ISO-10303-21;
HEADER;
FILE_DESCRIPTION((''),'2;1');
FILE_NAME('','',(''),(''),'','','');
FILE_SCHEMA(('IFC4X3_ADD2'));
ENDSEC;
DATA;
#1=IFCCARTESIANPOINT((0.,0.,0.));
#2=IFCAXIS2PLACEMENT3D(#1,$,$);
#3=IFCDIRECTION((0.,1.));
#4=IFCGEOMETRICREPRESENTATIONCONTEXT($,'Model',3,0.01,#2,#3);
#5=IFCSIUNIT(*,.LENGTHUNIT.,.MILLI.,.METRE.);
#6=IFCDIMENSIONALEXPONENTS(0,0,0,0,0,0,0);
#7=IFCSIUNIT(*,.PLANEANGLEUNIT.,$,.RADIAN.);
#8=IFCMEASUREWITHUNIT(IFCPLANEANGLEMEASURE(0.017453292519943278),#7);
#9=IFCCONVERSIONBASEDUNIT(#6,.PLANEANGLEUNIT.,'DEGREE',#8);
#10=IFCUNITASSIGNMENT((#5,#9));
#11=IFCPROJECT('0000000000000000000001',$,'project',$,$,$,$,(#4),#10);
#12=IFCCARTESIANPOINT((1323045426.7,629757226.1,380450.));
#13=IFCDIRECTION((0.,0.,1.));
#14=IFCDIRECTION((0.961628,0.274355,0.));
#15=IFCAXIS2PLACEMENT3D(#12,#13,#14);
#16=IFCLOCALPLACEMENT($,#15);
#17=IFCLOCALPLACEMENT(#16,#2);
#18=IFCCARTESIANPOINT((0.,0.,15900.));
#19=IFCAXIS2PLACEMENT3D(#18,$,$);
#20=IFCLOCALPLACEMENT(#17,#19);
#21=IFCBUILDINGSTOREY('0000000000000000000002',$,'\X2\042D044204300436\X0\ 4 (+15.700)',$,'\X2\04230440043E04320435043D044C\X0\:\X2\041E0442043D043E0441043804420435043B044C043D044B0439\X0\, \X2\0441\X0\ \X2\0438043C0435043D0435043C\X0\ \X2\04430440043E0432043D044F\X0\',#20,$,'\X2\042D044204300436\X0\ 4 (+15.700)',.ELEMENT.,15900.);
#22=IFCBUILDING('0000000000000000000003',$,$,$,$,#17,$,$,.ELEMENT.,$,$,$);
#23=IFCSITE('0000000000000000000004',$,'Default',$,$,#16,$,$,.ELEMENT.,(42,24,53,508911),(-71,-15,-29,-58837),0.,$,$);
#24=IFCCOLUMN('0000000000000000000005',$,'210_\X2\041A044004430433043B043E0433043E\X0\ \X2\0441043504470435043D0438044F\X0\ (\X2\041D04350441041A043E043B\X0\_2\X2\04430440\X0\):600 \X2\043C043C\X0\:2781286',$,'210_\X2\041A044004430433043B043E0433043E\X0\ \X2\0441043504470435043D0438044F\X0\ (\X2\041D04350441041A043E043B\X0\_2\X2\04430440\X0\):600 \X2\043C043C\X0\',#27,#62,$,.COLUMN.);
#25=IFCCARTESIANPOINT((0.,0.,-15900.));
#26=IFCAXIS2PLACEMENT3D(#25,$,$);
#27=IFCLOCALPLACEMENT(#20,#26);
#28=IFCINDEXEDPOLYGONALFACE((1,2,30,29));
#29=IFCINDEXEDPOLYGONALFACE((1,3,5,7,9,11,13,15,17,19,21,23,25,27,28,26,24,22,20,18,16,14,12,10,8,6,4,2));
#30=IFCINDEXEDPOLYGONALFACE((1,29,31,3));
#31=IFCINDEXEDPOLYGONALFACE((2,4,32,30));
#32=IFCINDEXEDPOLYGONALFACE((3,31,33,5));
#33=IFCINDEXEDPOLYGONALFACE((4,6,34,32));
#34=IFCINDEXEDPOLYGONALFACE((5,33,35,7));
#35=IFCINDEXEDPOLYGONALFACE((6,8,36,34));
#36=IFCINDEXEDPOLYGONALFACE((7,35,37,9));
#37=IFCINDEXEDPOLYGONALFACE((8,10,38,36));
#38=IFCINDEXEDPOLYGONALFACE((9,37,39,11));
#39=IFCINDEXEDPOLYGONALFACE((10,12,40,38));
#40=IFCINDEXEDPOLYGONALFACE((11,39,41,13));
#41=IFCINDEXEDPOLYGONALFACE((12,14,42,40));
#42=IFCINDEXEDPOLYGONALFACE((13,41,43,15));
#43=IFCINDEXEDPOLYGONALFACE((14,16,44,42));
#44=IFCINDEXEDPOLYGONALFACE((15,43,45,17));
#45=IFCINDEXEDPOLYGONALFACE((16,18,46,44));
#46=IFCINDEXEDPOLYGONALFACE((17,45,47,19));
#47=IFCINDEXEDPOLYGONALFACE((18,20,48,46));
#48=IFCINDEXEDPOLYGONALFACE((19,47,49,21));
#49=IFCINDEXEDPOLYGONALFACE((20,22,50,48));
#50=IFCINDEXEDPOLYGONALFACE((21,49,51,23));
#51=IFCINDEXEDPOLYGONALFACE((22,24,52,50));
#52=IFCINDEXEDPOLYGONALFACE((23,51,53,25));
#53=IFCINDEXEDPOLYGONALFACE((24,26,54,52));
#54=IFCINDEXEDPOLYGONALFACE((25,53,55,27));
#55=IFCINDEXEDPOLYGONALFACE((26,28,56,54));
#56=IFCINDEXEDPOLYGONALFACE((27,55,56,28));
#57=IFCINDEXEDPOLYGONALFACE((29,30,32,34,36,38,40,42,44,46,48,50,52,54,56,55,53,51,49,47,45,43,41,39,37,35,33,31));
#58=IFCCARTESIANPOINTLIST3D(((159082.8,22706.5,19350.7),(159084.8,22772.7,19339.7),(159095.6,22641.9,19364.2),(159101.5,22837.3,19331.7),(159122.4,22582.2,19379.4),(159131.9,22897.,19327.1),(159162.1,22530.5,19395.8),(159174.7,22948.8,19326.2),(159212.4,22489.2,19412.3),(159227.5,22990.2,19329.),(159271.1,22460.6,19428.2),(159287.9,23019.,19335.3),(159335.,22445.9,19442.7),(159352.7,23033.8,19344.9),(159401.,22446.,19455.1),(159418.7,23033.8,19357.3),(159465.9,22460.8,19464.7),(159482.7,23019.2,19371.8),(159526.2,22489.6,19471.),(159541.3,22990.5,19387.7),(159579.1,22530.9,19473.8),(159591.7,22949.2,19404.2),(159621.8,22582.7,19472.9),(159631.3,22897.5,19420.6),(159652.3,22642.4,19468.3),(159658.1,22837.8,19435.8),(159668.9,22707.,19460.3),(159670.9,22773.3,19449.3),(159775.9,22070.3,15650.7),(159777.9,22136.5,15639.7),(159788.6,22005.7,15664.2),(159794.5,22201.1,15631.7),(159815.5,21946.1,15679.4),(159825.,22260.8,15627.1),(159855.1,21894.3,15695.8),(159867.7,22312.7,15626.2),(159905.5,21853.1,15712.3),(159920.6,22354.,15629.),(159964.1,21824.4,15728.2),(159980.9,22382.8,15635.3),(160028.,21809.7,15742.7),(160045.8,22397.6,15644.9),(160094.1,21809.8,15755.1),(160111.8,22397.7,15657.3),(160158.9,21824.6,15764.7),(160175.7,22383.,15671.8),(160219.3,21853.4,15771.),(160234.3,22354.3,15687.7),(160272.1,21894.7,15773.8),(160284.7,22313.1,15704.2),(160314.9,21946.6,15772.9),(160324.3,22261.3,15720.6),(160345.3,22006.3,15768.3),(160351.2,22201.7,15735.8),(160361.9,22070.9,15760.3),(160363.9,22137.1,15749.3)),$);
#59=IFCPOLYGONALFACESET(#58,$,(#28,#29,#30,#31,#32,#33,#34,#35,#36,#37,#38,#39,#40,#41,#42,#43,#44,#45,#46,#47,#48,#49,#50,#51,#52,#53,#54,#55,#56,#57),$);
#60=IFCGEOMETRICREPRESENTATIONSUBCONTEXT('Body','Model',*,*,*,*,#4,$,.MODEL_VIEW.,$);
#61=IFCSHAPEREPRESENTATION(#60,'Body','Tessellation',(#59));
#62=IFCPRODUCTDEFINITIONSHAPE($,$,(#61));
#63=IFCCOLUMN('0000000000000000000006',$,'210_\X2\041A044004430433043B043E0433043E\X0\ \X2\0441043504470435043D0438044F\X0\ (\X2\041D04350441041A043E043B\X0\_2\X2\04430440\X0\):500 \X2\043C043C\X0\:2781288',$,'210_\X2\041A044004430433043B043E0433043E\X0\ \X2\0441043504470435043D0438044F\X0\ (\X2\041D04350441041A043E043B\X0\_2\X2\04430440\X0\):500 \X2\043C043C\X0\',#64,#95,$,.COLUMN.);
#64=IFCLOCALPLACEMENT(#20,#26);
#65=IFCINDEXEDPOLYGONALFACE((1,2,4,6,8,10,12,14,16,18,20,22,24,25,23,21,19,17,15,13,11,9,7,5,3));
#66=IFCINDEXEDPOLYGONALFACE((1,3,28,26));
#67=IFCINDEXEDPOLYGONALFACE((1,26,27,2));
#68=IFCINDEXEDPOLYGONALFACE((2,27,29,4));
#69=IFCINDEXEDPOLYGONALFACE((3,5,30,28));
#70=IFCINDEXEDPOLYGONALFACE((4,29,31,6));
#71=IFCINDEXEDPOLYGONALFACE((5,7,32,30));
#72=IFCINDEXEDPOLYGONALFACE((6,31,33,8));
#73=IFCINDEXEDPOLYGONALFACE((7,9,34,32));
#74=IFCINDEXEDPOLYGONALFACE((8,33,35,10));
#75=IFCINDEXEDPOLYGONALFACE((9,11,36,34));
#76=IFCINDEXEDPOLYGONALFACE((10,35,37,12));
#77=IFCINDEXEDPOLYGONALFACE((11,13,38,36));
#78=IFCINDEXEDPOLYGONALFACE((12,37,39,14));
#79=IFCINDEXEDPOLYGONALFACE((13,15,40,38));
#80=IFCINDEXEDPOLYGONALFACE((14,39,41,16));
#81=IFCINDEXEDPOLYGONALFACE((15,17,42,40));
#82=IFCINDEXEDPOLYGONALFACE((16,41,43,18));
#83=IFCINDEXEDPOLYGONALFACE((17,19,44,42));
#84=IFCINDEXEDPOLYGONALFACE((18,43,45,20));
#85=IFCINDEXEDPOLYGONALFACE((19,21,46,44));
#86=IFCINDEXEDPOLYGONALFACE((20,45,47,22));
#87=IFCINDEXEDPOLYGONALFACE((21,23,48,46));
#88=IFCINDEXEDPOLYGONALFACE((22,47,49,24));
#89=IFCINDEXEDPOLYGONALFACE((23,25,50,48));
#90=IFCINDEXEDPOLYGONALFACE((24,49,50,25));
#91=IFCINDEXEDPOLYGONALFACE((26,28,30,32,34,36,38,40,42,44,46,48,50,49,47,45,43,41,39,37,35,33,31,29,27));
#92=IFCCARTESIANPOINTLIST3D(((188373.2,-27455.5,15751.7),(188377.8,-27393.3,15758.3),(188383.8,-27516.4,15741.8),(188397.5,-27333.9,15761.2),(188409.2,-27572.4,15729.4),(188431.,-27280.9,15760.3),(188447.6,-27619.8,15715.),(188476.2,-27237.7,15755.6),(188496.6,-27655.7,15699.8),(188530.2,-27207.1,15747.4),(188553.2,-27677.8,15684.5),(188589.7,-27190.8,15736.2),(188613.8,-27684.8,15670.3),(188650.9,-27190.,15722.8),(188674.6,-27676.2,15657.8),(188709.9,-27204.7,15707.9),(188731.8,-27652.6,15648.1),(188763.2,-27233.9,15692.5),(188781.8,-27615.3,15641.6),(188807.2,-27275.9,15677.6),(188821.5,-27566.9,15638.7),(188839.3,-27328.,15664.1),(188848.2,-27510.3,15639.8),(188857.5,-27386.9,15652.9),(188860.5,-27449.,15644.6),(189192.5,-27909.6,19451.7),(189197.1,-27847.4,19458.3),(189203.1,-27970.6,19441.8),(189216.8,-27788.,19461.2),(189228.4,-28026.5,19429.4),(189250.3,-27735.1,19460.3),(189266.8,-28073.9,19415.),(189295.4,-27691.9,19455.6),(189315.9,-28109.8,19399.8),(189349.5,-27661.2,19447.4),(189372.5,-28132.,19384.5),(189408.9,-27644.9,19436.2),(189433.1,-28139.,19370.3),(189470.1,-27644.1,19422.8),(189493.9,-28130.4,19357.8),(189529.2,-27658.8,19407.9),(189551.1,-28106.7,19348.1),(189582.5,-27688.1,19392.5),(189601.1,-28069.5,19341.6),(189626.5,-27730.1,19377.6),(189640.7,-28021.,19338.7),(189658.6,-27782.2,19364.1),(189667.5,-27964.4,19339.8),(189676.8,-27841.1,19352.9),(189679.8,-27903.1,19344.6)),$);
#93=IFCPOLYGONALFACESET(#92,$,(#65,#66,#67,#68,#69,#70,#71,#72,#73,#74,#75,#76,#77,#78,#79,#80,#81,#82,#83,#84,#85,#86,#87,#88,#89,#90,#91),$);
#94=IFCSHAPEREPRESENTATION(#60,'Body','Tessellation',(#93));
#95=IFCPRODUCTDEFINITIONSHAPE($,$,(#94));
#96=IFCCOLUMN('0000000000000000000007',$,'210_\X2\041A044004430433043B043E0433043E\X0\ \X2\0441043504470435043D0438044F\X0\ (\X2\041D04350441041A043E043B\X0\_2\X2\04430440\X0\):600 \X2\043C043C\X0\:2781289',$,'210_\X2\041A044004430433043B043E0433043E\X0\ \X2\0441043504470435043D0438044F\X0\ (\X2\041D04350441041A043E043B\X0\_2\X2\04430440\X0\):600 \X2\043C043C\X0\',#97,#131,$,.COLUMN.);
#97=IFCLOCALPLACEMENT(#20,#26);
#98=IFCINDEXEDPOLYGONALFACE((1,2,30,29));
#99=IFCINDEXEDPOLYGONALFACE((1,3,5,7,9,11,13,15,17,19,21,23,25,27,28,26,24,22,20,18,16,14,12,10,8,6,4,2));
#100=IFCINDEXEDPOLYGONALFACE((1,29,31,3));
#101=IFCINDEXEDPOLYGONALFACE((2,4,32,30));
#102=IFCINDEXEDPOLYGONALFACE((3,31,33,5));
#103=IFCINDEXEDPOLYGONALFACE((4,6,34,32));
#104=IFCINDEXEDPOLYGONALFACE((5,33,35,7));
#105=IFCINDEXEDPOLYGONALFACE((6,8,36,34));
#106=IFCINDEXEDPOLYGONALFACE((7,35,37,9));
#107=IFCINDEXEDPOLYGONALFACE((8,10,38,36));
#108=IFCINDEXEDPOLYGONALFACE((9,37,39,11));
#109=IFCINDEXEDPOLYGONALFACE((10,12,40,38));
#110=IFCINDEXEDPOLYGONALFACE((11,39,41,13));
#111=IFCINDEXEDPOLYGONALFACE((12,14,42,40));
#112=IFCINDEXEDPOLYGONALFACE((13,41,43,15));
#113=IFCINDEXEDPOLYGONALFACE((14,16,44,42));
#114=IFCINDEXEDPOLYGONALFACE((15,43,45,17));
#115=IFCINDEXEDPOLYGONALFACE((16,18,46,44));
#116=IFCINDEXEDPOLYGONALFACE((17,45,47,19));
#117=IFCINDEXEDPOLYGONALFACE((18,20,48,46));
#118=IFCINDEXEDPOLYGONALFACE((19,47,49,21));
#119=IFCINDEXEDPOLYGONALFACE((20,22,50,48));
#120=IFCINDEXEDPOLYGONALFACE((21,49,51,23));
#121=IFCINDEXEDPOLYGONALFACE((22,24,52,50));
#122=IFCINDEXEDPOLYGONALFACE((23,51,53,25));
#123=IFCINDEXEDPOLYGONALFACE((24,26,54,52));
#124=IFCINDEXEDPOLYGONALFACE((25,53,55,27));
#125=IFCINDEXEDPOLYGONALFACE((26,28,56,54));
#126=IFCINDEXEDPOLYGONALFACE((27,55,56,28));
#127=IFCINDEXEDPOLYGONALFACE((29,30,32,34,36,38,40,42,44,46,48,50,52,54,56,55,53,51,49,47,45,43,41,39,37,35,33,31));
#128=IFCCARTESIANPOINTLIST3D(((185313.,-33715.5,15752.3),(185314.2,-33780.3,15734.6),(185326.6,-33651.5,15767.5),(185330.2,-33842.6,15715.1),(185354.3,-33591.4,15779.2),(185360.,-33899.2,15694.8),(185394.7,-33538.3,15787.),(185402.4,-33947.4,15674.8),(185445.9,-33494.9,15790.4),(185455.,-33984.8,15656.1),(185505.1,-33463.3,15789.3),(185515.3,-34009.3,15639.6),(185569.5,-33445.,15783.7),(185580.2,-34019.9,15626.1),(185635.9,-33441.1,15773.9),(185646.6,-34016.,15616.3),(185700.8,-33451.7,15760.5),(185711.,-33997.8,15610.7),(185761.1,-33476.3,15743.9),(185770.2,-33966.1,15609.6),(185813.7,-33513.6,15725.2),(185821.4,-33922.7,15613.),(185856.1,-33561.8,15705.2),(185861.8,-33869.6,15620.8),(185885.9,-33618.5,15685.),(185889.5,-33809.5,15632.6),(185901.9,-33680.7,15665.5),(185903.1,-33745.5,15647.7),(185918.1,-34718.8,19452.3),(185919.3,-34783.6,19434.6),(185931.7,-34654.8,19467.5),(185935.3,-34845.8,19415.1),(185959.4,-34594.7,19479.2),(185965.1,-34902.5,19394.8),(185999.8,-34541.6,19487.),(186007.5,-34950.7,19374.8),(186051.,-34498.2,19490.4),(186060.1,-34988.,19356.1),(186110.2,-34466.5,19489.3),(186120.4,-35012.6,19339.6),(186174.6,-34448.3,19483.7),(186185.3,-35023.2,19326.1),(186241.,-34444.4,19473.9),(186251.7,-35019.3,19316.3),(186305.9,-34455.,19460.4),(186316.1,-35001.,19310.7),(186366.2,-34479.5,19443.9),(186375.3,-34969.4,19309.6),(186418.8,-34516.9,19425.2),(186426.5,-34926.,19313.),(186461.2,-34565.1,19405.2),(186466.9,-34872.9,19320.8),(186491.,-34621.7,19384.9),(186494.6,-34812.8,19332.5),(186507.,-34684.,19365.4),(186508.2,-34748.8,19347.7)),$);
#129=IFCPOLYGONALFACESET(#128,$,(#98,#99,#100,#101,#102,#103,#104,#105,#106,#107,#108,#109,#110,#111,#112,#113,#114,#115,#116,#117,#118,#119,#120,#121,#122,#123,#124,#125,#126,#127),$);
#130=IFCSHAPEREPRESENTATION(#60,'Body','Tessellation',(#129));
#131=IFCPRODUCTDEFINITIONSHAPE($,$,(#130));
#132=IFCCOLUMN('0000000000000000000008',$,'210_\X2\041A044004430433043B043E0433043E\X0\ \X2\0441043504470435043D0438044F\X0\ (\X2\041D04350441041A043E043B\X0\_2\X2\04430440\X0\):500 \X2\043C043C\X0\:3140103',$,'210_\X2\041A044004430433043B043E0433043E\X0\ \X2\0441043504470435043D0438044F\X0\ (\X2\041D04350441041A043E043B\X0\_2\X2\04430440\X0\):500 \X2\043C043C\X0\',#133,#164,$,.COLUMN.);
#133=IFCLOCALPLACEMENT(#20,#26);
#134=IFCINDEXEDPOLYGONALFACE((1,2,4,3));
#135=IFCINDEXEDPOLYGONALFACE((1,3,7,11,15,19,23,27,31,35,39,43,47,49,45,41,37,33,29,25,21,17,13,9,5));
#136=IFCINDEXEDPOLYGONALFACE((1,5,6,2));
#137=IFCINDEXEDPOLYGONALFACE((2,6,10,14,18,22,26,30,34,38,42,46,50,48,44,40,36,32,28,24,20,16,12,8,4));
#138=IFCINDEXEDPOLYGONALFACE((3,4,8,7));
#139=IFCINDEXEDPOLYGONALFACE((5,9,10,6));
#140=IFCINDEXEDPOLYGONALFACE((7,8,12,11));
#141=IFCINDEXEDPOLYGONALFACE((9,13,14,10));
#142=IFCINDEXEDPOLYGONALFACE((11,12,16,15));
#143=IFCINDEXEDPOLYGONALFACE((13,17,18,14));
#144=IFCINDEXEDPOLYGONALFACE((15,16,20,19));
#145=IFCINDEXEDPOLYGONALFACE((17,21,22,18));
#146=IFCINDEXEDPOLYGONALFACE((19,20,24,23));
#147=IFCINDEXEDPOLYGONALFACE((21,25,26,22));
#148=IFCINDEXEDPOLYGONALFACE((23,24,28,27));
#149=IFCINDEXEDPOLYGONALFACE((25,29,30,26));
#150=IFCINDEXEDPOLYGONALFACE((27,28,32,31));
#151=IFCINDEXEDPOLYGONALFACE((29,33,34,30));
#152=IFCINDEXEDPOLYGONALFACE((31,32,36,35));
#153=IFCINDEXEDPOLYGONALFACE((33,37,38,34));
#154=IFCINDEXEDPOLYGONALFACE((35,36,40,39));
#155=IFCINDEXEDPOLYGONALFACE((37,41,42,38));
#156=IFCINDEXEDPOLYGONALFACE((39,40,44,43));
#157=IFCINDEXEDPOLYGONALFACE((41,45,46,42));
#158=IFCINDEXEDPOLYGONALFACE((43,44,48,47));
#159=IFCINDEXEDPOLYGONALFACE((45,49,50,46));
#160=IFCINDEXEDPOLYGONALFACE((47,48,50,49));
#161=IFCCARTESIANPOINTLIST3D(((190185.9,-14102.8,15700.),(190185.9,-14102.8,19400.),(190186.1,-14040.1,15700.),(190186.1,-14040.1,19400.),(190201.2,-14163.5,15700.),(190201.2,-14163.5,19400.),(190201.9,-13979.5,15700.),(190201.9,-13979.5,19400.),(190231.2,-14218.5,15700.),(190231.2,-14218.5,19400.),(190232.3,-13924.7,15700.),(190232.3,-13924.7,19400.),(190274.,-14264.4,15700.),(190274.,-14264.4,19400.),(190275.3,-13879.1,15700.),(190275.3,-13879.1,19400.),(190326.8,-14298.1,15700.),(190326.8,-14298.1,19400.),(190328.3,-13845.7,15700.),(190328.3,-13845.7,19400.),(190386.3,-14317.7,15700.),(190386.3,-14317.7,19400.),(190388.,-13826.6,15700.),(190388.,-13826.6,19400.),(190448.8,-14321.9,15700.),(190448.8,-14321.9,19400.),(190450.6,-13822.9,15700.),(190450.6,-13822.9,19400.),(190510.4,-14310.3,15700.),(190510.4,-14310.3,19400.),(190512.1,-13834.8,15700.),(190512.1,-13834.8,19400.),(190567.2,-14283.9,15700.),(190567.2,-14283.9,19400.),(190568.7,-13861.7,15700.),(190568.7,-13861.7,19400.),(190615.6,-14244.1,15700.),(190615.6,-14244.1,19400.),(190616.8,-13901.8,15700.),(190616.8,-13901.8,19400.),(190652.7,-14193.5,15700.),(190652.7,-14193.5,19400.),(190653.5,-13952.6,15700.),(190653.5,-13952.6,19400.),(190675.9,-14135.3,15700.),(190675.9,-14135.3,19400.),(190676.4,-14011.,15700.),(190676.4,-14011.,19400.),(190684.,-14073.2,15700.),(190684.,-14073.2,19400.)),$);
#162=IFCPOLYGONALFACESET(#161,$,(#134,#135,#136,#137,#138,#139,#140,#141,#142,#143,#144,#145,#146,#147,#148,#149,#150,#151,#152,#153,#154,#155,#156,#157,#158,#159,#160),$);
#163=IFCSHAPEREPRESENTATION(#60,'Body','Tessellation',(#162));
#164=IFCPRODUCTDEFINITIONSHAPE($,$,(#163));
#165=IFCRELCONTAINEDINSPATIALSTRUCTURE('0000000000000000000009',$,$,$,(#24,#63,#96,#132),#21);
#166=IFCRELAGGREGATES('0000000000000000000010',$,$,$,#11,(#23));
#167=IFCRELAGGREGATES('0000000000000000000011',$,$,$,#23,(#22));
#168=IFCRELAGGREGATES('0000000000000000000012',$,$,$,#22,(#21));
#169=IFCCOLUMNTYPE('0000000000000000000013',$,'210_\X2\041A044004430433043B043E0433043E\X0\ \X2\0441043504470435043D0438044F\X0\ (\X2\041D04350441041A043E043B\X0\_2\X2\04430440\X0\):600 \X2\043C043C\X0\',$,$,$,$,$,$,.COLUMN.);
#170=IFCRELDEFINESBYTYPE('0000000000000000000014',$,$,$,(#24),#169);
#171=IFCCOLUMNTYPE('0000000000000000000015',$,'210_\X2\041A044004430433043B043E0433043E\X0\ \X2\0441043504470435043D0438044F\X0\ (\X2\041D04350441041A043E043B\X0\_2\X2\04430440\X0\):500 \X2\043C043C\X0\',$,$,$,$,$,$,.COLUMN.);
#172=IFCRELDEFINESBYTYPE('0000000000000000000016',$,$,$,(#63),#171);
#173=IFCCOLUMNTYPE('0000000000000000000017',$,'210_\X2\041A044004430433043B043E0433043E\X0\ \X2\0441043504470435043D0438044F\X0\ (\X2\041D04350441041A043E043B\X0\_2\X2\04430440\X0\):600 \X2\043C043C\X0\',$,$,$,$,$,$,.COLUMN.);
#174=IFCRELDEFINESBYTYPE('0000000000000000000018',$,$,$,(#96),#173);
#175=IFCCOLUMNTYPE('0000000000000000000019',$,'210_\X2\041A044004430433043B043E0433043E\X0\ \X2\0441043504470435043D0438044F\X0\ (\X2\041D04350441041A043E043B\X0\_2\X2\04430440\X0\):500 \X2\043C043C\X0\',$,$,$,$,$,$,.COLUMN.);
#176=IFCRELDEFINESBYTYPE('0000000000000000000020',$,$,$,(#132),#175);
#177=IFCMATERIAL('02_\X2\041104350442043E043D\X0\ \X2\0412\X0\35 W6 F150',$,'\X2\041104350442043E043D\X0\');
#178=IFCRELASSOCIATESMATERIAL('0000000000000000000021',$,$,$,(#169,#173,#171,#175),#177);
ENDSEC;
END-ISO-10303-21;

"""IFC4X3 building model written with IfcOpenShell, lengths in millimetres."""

from ifc_helpers import new_model, entity, si_unit, converted_unit, direction, frame, frame_2d, origin, origin_2d_with_axis, place, context, subcontext, project, spatial, circle, extrude, source, transform, mapped, material, material_profile, profile_set, type_object, type_shapes, element, save


model = new_model("IFC4X3")

# Units and contexts
model_context = context("Model", 3, precision=0.01, world=origin(), true_north=direction((0.0, 1.0)))
body_context = subcontext(model_context, "Body", "Model", "MODEL_VIEW")
ifc_project = project(units=[si_unit("LENGTHUNIT", "METRE", prefix="MILLI"), converted_unit("PLANEANGLEUNIT", "DEGREE", entity("IfcPlaneAngleMeasure", 0.017453292519943278), si_unit("PLANEANGLEUNIT", "RADIAN"), dimensions=[0, 0, 0, 0, 0, 0, 0])], contexts=[model_context])

# Site, building, storey
site_placement = place(None, frame((1323045426.7, 629757226.1, 380450.0), z_axis=(0.0, 0.0, 1.0), x_axis=(0.961628, 0.274355, 0.0)))
site = spatial("IfcSite", under=ifc_project, at=site_placement, Name="Default", CompositionType="ELEMENT", RefLatitude=(42, 24, 53, 508911), RefLongitude=(-71, -15, -29, -58837), RefElevation=0.0)
building_placement = place(site_placement, origin())
building = spatial("IfcBuilding", under=site, at=building_placement, CompositionType="ELEMENT")
storey_placement = place(building_placement, frame((0.0, 0.0, 15900.0)))
storey = spatial("IfcBuildingStorey", under=building, at=storey_placement, Name="Этаж 4 (+15.700)", ObjectType="Уровень:Относительный, с именем уровня", LongName="Этаж 4 (+15.700)", CompositionType="ELEMENT", Elevation=15900.0)

# Columns
ifc_material = material(Name="02_Бетон В35 W6 F150", Category="Бетон")
ifc_material_profile_1 = material_profile(ifc_material, circle(Radius=300.0, at=frame_2d((0.0, 0.0), x_axis=(1.0, 0.0))), Name="600 мм")
ifc_profile_set_1 = profile_set([ifc_material_profile_1], Name="600 мм")
ifc_material_profile_2 = material_profile(ifc_material, circle(Radius=250.0, at=origin_2d_with_axis()), Name="500 мм")
ifc_profile_set_2 = profile_set([ifc_material_profile_2], Name="500 мм")
column_type_1 = type_object("IfcColumnType", Name="210_Круглого сечения (НесКол_2ур):600 мм", PredefinedType="COLUMN", material=ifc_profile_set_1)
shared_shape_1 = source(origin(), body_context, "Body", "SweptSolid", [
    extrude(circle(Radius=300.0, at=frame_2d((0.0, 0.0), x_axis=(1.0, 0.0))), frame((160069.9, 22103.7, 15700.0), z_axis=(-0.181533, 0.166636, 0.969164), x_axis=(-0.937586, -0.326588, -0.119466)), (0.0, 0.0, 1.0), 3817.7),
])
type_shapes(column_type_1, [shared_shape_1])
column_1_placement = place(storey_placement, frame((0.0, 0.0, -15900.0)))
element("IfcColumn", 1, at=column_1_placement, inside=storey, type_object=column_type_1, Name="210_Круглого сечения (НесКол_2ур):600 мм:2781286", ObjectType="210_Круглого сечения (НесКол_2ур):600 мм", PredefinedType="COLUMN", context=body_context, shape_type="MappedRepresentation", body=[
    mapped(shared_shape_1, transform((0.0, 0.0, 0.0), scale=1.0)),
])
column_type_2 = type_object("IfcColumnType", Name="210_Круглого сечения (НесКол_2ур):500 мм", PredefinedType="COLUMN", material=ifc_profile_set_2)
shared_shape_2 = source(origin(), body_context, "Body", "SweptSolid", [
    extrude(circle(Radius=250.0, at=origin_2d_with_axis()), frame((188617.0, -27436.6, 15700.0), z_axis=(0.214654, -0.118985, 0.969415), x_axis=(-0.012969, -0.992811, -0.118985)), (0.0, 0.0, 1.0), 3816.7),
])
type_shapes(column_type_2, [shared_shape_2])
column_2_placement = place(storey_placement, frame((0.0, 0.0, -15900.0)))
element("IfcColumn", 2, at=column_2_placement, inside=storey, type_object=column_type_2, Name="210_Круглого сечения (НесКол_2ур):500 мм:2781288", ObjectType="210_Круглого сечения (НесКол_2ур):500 мм", PredefinedType="COLUMN", context=body_context, shape_type="MappedRepresentation", body=[
    mapped(shared_shape_2, transform((0.0, 0.0, 0.0), scale=1.0)),
])
column_type_3 = type_object("IfcColumnType", Name="210_Круглого сечения (НесКол_2ур):600 мм", PredefinedType="COLUMN", material=ifc_profile_set_1)
shared_shape_3 = source(origin(), body_context, "Body", "SweptSolid", [
    extrude(circle(Radius=300.0, at=frame_2d((0.0, 0.0), x_axis=(1.0, 0.0))), frame((185608.0, -33730.5, 15700.0), z_axis=(0.155911, -0.258506, 0.953345), x_axis=(0.510241, 0.847487, 0.146356)), (0.0, 0.0, 1.0), 3881.0),
])
type_shapes(column_type_3, [shared_shape_3])
column_3_placement = place(storey_placement, frame((0.0, 0.0, -15900.0)))
element("IfcColumn", 3, at=column_3_placement, inside=storey, type_object=column_type_3, Name="210_Круглого сечения (НесКол_2ур):600 мм:2781289", ObjectType="210_Круглого сечения (НесКол_2ур):600 мм", PredefinedType="COLUMN", context=body_context, shape_type="MappedRepresentation", body=[
    mapped(shared_shape_3, transform((0.0, 0.0, 0.0), scale=1.0)),
])
column_type_4 = type_object("IfcColumnType", Name="210_Круглого сечения (НесКол_2ур):500 мм", PredefinedType="COLUMN", material=ifc_profile_set_2)
shared_shape_4 = source(origin(), body_context, "Body", "SweptSolid", [
    extrude(circle(Radius=250.0, at=origin_2d_with_axis()), frame((190434.0, -14072.3, 15700.0), z_axis=(0.0, 0.0, 1.0), x_axis=(0.87462, -0.48481, 0.0)), (0.0, 0.0, 1.0), 3700.0),
])
type_shapes(column_type_4, [shared_shape_4])
column_4_placement = place(storey_placement, frame((0.0, 0.0, -15900.0)))
element("IfcColumn", 4, at=column_4_placement, inside=storey, type_object=column_type_4, Name="210_Круглого сечения (НесКол_2ур):500 мм:3140103", ObjectType="210_Круглого сечения (НесКол_2ур):500 мм", PredefinedType="COLUMN", context=body_context, shape_type="MappedRepresentation", body=[
    mapped(shared_shape_4, transform((0.0, 0.0, 0.0), scale=1.0)),
])

save(model, "model.ifc")
